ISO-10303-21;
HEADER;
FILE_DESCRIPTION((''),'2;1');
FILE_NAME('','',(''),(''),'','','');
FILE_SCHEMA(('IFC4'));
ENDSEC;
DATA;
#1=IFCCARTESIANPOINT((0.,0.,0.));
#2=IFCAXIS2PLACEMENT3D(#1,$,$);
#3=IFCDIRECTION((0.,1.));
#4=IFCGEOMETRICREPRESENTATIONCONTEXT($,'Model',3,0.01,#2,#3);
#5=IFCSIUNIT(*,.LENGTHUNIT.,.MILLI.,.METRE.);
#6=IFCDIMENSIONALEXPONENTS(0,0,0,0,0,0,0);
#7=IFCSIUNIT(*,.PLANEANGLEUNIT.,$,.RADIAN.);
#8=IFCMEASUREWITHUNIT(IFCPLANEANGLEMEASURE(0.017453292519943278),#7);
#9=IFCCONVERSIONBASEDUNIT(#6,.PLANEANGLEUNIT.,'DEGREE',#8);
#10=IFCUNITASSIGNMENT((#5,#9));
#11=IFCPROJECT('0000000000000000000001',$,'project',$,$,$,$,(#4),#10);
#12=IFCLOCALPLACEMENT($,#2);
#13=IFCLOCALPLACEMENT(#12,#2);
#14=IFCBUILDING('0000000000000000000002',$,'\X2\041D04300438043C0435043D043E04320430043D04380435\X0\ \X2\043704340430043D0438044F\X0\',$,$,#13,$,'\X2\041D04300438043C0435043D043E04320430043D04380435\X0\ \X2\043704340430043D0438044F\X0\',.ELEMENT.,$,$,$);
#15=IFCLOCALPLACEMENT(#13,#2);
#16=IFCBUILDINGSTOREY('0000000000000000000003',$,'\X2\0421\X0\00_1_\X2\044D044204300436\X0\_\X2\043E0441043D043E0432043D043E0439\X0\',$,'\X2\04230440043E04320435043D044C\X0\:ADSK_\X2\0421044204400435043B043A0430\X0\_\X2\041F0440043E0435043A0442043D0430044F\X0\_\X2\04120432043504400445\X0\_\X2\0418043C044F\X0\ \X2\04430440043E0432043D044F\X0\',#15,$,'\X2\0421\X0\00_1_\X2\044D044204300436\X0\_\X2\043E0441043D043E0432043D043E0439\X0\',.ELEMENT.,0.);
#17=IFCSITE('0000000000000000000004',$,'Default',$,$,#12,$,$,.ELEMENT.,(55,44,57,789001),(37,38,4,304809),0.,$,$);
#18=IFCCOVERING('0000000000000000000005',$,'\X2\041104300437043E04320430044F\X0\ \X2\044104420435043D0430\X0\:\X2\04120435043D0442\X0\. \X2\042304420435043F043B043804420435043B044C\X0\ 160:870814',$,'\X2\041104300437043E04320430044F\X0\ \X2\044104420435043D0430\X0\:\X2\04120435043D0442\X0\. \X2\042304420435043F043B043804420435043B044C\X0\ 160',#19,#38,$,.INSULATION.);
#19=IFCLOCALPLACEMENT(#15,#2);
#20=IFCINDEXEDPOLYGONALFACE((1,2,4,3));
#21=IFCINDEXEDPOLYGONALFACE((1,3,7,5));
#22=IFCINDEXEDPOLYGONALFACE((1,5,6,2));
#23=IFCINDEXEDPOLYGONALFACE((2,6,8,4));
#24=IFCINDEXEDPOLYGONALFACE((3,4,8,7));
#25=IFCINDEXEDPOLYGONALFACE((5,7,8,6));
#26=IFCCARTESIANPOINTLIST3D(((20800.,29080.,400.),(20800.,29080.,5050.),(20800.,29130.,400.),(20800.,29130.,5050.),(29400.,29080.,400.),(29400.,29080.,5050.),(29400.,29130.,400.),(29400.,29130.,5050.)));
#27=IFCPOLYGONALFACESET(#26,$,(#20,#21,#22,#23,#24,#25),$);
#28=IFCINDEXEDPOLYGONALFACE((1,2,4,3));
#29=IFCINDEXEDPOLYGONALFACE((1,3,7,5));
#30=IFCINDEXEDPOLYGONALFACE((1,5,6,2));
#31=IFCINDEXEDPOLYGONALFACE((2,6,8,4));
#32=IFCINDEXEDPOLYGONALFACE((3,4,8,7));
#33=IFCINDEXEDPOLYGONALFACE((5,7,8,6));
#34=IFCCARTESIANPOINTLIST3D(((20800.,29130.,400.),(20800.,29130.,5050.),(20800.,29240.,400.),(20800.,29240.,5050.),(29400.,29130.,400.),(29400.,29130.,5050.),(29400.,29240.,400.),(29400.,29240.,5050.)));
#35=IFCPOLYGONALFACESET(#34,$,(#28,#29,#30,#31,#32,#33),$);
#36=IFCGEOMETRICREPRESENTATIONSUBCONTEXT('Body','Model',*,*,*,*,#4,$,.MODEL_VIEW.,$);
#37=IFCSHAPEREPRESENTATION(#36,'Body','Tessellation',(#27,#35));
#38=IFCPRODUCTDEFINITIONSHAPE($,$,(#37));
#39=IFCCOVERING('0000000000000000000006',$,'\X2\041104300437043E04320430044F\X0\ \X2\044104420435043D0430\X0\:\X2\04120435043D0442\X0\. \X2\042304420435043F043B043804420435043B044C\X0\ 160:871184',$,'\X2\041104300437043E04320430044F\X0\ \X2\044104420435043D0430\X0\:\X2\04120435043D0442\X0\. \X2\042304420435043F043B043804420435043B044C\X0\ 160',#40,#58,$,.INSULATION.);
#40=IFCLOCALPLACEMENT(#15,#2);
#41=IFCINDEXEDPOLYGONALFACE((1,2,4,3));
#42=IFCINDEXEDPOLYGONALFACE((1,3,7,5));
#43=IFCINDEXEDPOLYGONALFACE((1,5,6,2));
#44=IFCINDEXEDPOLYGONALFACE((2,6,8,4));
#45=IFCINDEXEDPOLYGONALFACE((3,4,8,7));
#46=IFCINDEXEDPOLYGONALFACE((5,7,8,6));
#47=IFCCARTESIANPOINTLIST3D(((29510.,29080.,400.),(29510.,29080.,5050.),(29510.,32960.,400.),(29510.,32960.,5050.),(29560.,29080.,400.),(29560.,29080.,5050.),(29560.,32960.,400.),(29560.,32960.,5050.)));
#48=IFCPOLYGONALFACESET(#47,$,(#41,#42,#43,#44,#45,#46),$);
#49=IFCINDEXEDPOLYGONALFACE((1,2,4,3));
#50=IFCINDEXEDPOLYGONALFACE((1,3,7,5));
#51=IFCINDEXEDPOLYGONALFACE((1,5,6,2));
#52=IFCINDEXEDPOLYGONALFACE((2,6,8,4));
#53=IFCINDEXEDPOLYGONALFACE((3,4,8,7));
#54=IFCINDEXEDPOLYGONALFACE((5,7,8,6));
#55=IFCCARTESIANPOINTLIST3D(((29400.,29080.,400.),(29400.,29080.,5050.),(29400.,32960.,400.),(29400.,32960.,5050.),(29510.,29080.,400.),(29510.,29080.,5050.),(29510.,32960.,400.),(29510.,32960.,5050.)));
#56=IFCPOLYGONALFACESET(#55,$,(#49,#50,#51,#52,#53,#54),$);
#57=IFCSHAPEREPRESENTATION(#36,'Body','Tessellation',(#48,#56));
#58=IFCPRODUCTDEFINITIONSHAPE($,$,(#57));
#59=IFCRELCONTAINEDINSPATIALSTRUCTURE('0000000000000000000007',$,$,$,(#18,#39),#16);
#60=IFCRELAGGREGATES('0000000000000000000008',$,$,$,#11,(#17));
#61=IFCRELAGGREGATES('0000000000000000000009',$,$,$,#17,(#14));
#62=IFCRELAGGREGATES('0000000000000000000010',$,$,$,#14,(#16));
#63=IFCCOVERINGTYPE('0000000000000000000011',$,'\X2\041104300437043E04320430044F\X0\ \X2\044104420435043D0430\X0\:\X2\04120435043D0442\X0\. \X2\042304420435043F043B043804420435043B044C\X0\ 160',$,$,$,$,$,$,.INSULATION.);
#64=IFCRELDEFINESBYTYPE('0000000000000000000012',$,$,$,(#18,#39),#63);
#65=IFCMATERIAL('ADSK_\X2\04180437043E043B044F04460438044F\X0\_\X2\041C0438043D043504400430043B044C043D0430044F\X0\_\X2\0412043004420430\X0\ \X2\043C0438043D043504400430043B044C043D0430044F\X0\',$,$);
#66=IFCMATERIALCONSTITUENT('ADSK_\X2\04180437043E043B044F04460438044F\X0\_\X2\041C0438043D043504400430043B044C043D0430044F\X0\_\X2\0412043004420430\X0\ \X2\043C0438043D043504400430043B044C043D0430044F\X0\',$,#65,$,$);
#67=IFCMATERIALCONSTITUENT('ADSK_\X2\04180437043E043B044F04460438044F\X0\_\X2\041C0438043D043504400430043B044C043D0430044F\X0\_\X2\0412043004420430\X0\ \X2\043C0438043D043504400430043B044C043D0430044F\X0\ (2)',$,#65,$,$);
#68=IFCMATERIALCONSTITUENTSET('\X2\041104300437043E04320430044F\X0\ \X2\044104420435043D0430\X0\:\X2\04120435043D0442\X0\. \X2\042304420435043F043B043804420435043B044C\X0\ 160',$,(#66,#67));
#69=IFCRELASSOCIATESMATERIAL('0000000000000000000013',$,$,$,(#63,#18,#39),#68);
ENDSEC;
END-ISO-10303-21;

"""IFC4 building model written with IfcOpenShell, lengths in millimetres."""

from ifc_helpers import new_model, entity, si_unit, converted_unit, direction, frame, origin, place, context, subcontext, project, spatial, indexed_curve, outline, extrude, material, constituent, constituent_set, type_object, element, save


model = new_model("IFC4")

# Units and contexts
model_context = context("Model", 3, precision=0.01, world=origin(), true_north=direction((0.0, 1.0)))
body_context = subcontext(model_context, "Body", "Model", "MODEL_VIEW")
ifc_project = project(units=[si_unit("LENGTHUNIT", "METRE", prefix="MILLI"), converted_unit("PLANEANGLEUNIT", "DEGREE", entity("IfcPlaneAngleMeasure", 0.017453292519943278), si_unit("PLANEANGLEUNIT", "RADIAN"), dimensions=[0, 0, 0, 0, 0, 0, 0])], contexts=[model_context])

# Site, building, storey
site_placement = place(None, origin())
site = spatial("IfcSite", under=ifc_project, at=site_placement, Name="Default", CompositionType="ELEMENT", RefLatitude=(55, 44, 57, 789001), RefLongitude=(37, 38, 4, 304809), RefElevation=0.0)
building_placement = place(site_placement, origin())
building = spatial("IfcBuilding", under=site, at=building_placement, Name="Наименование здания", LongName="Наименование здания", CompositionType="ELEMENT")
storey_placement = place(building_placement, origin())
storey = spatial("IfcBuildingStorey", under=building, at=storey_placement, Name="С00_1_этаж_основной", ObjectType="Уровень:ADSK_Стрелка_Проектная_Вверх_Имя уровня", LongName="С00_1_этаж_основной", CompositionType="ELEMENT", Elevation=0.0)

# Coverings
ifc_material_1 = material(Name="ADSK_Изоляция_Минеральная_Вата минеральная")
ifc_constituent_1 = constituent(ifc_material_1, Name="ADSK_Изоляция_Минеральная_Вата минеральная")
ifc_constituent_2 = constituent(ifc_material_1, Name="ADSK_Изоляция_Минеральная_Вата минеральная (2)")
ifc_constituent_set_1 = constituent_set(constituents=[ifc_constituent_1, ifc_constituent_2], Name="Базовая стена:Вент. Утеплитель 160")
covering_type = type_object("IfcCoveringType", Name="Базовая стена:Вент. Утеплитель 160", PredefinedType="INSULATION", material=ifc_constituent_set_1)
covering_1_placement = place(storey_placement, frame((29400.0, 29160.0, 400.0), z_axis=(0.0, 0.0, 1.0), x_axis=(-1.0, 0.0, 0.0)))
element("IfcCovering", 1, at=covering_1_placement, inside=storey, type_object=covering_type, material=ifc_constituent_set_1, Name="Базовая стена:Вент. Утеплитель 160:870814", ObjectType="Базовая стена:Вент. Утеплитель 160", PredefinedType="INSULATION", context=body_context, shape_type="SweptSolid", body=[
    extrude(outline(indexed_curve([(-25.0, -4300.0), (25.0, -4300.0), (25.0, 4300.0), (-25.0, 4300.0), (-25.0, -4300.0)], self_intersect=False)), frame((4300.0, 55.0, 0.0), z_axis=(0.0, 0.0, 1.0), x_axis=(0.0, -1.0, 0.0)), (0.0, 0.0, 1.0), 4650.0),
    extrude(outline(indexed_curve([(-55.0, -4300.0), (55.0, -4300.0), (55.0, 4300.0), (-55.0, 4300.0), (-55.0, -4300.0)], self_intersect=False)), frame((4300.0, -25.0, 0.0), z_axis=(0.0, 0.0, 1.0), x_axis=(0.0, 1.0, 0.0)), (0.0, 0.0, 1.0), 4650.0),
])
covering_2_placement = place(storey_placement, frame((29480.0, 29080.0, 400.0), z_axis=(0.0, 0.0, 1.0), x_axis=(0.0, 1.0, 0.0)))
element("IfcCovering", 2, at=covering_2_placement, inside=storey, type_object=covering_type, material=ifc_constituent_set_1, Name="Базовая стена:Вент. Утеплитель 160:871184", ObjectType="Базовая стена:Вент. Утеплитель 160", PredefinedType="INSULATION", context=body_context, shape_type="SweptSolid", body=[
    extrude(outline(indexed_curve([(-25.0, -1940.0), (25.0, -1940.0), (25.0, 1940.0), (-25.0, 1940.0), (-25.0, -1940.0)], self_intersect=False)), frame((1940.0, -55.0, 0.0), z_axis=(0.0, 0.0, 1.0), x_axis=(0.0, 1.0, 0.0)), (0.0, 0.0, 1.0), 4650.0),
    extrude(outline(indexed_curve([(-55.0, -1940.0), (55.0, -1940.0), (55.0, 1940.0), (-55.0, 1940.0), (-55.0, -1940.0)], self_intersect=False)), frame((1940.0, 25.0, 0.0), z_axis=(0.0, 0.0, 1.0), x_axis=(0.0, -1.0, 0.0)), (0.0, 0.0, 1.0), 4650.0),
])

save(model, "model.ifc")
